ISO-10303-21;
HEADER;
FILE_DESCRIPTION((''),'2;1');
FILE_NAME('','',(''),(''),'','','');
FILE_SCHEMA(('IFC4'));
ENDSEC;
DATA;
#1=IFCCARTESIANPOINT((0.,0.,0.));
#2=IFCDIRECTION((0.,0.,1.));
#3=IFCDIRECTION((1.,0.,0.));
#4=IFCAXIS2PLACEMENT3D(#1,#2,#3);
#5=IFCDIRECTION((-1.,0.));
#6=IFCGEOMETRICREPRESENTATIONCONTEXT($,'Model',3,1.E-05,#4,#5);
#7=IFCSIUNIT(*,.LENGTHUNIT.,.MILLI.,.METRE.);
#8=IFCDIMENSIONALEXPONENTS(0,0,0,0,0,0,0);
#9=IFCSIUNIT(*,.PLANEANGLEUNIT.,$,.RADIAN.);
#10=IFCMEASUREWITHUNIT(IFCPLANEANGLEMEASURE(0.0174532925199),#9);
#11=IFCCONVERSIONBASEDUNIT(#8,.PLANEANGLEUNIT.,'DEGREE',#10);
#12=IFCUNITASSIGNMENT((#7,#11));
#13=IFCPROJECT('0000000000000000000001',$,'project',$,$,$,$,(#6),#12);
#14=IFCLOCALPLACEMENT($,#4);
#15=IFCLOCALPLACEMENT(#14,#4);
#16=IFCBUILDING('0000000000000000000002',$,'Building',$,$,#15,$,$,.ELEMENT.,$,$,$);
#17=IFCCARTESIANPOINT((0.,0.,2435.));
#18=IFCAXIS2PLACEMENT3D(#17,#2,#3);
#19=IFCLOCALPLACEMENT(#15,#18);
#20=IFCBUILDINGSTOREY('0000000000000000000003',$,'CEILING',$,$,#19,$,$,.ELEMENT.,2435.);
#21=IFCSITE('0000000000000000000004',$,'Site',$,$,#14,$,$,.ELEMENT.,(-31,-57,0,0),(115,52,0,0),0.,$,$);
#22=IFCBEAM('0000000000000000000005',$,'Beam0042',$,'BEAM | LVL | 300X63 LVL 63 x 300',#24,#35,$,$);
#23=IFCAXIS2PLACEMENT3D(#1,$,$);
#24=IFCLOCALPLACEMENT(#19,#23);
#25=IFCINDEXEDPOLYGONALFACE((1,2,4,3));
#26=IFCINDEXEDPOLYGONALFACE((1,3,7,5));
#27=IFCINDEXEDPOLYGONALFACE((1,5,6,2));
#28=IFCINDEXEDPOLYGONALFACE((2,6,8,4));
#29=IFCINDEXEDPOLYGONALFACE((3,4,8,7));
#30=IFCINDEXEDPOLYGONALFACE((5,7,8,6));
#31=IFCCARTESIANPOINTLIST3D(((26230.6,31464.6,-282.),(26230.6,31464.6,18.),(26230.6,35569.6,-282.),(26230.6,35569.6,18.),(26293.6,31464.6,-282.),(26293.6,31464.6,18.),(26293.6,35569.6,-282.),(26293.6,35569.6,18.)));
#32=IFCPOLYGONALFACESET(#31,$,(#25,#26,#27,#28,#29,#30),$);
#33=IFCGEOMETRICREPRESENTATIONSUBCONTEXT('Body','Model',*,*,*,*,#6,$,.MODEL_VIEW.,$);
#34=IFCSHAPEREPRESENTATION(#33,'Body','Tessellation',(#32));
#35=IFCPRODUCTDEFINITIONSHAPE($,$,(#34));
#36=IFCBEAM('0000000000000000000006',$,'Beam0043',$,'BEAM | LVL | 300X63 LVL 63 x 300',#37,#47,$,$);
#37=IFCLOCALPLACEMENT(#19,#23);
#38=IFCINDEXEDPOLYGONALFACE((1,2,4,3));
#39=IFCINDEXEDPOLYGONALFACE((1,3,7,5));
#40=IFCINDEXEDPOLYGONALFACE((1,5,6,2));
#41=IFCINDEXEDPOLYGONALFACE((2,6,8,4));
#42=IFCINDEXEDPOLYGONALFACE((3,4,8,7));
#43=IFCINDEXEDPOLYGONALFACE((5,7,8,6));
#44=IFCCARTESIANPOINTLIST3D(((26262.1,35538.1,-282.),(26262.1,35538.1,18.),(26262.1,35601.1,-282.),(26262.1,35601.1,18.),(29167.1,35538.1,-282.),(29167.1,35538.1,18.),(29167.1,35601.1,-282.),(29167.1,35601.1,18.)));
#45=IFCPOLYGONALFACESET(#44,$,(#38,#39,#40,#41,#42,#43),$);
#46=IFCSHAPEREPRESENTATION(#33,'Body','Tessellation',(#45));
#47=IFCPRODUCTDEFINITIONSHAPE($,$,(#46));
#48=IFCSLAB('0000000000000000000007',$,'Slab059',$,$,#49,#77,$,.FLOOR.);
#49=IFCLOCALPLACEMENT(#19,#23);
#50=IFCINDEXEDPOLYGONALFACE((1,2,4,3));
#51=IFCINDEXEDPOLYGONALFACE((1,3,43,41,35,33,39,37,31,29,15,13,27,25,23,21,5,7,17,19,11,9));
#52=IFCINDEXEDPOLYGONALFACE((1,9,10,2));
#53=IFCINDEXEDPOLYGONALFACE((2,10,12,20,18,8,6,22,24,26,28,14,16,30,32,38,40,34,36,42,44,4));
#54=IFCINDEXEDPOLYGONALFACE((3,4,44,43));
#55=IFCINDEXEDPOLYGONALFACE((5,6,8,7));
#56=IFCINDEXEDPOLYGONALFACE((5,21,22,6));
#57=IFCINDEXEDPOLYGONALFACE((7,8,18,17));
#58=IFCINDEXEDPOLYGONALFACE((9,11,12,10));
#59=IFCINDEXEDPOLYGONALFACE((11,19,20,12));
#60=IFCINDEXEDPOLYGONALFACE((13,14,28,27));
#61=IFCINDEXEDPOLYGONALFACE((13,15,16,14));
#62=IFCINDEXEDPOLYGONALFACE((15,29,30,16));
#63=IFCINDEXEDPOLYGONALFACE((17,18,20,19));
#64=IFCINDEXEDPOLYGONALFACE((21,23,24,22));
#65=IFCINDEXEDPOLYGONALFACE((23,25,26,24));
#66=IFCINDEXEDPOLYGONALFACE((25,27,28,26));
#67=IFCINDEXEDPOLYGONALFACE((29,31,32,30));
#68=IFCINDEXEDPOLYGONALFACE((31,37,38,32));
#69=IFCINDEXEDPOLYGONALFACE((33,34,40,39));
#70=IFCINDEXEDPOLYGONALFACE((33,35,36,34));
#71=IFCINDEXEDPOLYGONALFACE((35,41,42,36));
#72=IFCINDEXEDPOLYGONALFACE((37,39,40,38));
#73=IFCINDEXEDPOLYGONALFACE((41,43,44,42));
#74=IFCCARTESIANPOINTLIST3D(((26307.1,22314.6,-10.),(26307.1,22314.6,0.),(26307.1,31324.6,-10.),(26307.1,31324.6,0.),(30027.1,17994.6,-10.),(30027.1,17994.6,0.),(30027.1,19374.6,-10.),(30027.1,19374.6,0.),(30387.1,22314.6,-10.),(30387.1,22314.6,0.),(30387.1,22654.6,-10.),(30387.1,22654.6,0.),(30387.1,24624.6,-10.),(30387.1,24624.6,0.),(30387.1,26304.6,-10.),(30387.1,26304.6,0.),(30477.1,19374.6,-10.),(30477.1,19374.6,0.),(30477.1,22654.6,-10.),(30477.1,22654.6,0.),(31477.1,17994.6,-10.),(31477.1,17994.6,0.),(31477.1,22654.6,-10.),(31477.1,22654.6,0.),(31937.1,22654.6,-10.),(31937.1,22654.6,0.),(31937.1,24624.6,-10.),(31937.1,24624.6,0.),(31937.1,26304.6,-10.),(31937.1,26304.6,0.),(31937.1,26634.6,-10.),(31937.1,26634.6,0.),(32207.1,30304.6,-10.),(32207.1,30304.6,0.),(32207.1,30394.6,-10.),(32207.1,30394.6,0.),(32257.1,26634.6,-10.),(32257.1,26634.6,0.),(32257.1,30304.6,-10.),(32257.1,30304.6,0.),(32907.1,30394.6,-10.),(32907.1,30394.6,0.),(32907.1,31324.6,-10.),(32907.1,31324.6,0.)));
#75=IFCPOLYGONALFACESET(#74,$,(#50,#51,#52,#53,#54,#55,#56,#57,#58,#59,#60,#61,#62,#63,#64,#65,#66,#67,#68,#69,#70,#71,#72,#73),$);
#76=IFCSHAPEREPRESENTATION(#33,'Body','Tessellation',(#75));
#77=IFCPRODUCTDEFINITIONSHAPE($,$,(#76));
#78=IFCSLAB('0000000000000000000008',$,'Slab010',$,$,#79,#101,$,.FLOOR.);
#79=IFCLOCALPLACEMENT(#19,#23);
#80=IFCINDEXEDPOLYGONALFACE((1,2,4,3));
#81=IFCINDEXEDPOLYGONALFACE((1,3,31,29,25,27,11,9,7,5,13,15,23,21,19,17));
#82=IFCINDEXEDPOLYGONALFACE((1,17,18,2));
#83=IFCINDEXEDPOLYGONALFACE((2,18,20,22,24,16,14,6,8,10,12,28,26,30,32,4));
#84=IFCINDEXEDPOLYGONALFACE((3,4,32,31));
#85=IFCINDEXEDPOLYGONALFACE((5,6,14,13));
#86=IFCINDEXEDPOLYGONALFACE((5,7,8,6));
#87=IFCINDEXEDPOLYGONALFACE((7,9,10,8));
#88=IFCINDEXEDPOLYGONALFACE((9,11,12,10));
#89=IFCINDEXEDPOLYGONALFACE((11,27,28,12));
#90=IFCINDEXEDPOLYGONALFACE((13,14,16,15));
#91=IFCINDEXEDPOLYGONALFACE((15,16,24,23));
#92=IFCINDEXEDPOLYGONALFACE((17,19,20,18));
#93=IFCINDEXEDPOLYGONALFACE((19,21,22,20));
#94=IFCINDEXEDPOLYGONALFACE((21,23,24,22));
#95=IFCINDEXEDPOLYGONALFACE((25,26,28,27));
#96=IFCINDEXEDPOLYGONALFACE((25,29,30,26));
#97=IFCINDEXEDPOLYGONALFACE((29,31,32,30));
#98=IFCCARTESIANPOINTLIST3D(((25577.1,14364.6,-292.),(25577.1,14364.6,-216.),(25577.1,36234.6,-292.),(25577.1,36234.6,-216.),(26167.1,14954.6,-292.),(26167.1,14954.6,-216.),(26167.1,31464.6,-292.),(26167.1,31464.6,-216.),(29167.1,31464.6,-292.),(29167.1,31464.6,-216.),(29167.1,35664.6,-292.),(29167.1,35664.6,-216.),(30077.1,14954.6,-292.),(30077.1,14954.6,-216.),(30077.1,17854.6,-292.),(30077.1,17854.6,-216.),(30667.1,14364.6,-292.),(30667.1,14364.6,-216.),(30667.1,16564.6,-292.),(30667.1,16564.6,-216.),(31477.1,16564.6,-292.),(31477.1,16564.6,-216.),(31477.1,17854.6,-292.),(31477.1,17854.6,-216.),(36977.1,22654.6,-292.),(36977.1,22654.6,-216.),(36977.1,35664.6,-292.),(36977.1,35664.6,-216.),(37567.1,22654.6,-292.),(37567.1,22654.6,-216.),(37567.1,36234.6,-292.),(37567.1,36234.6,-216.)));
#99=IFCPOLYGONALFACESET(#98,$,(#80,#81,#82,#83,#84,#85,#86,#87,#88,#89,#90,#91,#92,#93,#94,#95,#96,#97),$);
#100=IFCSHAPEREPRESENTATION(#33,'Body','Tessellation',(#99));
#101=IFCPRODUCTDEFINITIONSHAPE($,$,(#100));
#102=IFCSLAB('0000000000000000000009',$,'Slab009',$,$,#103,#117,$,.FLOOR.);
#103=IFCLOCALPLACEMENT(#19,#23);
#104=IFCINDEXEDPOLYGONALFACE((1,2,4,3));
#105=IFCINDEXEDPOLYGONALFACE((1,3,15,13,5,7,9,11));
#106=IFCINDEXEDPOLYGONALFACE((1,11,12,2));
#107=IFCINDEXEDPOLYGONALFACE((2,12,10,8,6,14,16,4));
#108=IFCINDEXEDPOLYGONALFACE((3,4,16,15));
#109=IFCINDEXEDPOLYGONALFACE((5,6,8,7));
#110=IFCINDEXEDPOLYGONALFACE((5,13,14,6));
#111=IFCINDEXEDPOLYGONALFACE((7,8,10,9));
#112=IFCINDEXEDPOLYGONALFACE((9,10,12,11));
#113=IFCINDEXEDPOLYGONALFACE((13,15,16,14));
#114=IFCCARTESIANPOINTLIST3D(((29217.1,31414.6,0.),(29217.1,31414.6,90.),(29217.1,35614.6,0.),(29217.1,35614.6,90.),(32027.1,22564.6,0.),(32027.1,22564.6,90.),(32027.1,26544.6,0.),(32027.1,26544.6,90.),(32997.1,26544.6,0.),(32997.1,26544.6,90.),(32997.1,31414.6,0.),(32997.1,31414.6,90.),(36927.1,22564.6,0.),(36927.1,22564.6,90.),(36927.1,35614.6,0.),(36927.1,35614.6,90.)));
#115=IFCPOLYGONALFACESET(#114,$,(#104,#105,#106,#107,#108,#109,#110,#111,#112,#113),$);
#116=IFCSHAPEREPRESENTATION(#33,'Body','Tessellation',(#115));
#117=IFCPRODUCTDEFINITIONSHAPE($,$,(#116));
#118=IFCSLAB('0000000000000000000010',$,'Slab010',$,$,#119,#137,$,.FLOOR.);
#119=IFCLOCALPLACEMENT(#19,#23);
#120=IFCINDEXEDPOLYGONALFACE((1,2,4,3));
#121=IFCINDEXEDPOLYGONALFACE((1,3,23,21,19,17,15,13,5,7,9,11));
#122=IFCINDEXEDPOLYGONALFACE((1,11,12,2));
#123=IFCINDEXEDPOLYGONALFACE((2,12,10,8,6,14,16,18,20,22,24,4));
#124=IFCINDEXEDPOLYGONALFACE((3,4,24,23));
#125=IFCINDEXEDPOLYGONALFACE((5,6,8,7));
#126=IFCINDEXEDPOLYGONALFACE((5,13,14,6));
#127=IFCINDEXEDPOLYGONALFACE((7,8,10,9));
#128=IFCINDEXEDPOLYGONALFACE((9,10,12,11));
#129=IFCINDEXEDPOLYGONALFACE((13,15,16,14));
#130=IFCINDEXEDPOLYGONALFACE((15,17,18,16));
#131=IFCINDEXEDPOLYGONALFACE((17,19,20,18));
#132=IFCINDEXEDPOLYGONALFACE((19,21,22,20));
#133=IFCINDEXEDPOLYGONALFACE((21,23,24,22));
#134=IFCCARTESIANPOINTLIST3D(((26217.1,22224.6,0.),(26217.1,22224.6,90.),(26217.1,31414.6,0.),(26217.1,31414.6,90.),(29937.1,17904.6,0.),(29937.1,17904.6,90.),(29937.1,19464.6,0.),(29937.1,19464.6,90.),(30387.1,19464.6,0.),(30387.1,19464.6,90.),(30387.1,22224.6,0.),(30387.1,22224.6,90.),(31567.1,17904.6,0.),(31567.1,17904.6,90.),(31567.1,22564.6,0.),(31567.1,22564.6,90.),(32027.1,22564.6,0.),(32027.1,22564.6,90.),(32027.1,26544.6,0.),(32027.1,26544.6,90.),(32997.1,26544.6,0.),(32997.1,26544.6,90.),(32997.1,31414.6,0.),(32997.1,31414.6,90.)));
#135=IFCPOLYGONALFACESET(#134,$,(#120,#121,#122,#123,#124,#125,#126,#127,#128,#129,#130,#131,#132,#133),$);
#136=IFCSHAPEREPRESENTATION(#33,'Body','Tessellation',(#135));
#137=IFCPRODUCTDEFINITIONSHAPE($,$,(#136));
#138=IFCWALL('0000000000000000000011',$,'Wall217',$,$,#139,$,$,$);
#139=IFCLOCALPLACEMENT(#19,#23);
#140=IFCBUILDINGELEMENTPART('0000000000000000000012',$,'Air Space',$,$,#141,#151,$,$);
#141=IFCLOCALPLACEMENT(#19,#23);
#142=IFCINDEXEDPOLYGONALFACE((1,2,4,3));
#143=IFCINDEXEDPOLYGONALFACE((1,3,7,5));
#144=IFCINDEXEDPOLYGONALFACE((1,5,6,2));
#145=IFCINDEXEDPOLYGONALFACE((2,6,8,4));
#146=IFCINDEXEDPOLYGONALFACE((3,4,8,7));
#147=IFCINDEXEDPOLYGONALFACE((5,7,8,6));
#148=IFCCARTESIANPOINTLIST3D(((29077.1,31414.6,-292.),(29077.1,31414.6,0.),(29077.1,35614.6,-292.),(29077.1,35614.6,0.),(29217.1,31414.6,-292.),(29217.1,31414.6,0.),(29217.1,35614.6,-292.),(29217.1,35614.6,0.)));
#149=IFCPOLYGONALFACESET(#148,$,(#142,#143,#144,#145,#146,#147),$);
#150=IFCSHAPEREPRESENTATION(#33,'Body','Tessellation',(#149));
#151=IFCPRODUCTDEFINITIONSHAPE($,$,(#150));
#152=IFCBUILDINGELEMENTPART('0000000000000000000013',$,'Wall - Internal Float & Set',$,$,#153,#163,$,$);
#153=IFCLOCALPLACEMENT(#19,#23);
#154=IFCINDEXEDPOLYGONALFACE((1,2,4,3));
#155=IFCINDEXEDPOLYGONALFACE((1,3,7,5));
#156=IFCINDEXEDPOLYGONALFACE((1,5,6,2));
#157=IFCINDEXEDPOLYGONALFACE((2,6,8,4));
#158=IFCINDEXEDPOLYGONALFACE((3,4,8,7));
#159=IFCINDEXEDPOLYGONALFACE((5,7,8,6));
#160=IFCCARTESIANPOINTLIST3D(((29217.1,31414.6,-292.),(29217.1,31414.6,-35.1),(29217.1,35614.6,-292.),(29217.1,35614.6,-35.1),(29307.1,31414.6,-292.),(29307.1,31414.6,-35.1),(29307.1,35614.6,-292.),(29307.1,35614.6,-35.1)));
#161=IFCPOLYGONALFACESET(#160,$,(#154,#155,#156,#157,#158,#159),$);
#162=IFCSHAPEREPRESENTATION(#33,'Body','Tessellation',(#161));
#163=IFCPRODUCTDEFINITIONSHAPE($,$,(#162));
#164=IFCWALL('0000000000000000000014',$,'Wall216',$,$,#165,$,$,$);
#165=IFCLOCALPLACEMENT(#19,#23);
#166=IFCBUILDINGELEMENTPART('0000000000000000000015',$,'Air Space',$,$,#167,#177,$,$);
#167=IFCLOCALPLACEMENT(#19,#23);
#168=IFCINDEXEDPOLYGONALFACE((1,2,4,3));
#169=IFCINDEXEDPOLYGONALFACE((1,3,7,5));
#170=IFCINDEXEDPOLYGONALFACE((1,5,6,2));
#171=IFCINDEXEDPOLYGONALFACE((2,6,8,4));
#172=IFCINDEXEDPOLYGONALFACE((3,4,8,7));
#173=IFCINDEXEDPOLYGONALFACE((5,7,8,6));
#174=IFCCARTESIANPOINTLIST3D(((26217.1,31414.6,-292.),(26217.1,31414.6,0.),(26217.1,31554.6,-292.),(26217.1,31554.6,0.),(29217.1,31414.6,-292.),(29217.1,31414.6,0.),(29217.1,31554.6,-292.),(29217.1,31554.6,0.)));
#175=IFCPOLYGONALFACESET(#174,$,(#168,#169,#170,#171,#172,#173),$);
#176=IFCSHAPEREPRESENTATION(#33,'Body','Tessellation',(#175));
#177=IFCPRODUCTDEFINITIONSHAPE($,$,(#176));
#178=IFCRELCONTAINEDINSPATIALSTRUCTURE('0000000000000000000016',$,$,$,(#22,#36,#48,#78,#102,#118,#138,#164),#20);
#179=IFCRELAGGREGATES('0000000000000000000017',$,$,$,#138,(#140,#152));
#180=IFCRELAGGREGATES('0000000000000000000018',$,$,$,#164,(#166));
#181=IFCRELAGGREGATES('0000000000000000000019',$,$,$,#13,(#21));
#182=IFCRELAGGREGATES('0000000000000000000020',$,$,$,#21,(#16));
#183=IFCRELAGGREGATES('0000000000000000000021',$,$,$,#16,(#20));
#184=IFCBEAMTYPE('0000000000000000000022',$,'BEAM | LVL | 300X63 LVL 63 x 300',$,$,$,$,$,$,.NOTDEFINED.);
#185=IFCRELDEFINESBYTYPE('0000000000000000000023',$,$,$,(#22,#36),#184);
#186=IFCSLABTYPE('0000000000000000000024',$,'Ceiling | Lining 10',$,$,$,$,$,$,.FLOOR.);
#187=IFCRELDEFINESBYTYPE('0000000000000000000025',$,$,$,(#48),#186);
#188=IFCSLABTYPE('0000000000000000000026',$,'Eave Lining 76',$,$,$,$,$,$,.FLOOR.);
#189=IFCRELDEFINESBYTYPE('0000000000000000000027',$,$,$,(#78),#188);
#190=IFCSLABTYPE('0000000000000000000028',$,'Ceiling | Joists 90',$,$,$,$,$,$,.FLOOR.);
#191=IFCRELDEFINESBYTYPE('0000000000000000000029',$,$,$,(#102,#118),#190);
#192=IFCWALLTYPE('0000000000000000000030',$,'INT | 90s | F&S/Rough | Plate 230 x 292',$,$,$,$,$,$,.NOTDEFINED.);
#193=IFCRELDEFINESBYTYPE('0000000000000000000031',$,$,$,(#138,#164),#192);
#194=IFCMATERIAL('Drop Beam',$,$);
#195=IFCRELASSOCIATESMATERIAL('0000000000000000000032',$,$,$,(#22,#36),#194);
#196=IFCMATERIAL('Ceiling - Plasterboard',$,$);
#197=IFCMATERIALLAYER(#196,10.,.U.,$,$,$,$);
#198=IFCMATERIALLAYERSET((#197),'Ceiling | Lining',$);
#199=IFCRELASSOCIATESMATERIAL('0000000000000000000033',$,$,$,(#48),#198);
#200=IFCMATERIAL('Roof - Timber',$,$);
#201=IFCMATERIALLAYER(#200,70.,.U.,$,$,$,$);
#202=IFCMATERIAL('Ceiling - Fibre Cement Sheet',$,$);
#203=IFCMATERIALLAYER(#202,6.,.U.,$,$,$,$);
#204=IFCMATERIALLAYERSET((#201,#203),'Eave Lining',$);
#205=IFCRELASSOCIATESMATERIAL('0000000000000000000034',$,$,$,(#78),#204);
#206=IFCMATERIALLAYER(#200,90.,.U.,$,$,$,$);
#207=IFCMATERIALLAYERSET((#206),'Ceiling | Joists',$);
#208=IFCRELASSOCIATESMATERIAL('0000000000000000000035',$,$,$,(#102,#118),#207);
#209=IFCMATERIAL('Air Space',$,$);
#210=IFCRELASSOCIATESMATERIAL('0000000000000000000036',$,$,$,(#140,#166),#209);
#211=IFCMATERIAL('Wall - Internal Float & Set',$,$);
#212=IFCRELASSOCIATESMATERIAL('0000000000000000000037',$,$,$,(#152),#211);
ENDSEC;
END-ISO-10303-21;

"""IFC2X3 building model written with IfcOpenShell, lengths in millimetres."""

from ifc_helpers import new_model, entity, si_unit, converted_unit, direction, frame, origin_with_axes, place, context, subcontext, project, spatial, polyline, outline, extrude, material, layer, layer_set, layer_usage, type_object, element, aggregate, save


model = new_model("IFC2X3")

# Units and contexts
model_context = context("Model", 3, precision=1e-05, world=origin_with_axes(), true_north=direction((-1.0, 0.0)))
body_context = subcontext(model_context, "Body", "Model", "MODEL_VIEW")
ifc_project = project(units=[si_unit("LENGTHUNIT", "METRE", prefix="MILLI"), converted_unit("PLANEANGLEUNIT", "DEGREE", entity("IfcPlaneAngleMeasure", 0.0174532925199), si_unit("PLANEANGLEUNIT", "RADIAN"), dimensions=[0, 0, 0, 0, 0, 0, 0])], contexts=[model_context])

# Site, building, storey
site_placement = place(None, origin_with_axes())
site = spatial("IfcSite", under=ifc_project, at=site_placement, Name="Site", CompositionType="ELEMENT", RefLatitude=(-31, -57, 0, 0), RefLongitude=(115, 52, 0, 0), RefElevation=0.0)
building_placement = place(site_placement, origin_with_axes())
building = spatial("IfcBuilding", under=site, at=building_placement, Name="Building", CompositionType="ELEMENT")
storey_placement = place(building_placement, frame((0.0, 0.0, 2435.0), z_axis=(0.0, 0.0, 1.0), x_axis=(1.0, 0.0, 0.0)))
storey = spatial("IfcBuildingStorey", under=building, at=storey_placement, Name="CEILING", CompositionType="ELEMENT", Elevation=2435.0)

# Beams
ifc_material_1 = material(Name="Drop Beam")
beam_type = type_object("IfcBeamType", Name="BEAM | LVL | 300X63 LVL 63 x 300", PredefinedType="NOTDEFINED")
beam_1_placement = place(storey_placement, frame((26262.1, 31464.6, -282.0), z_axis=(0.0, 0.0, 1.0), x_axis=(1.0, 0.0, 0.0)))
element("IfcBeam", 1, at=beam_1_placement, inside=storey, type_object=beam_type, material=ifc_material_1, Name="Beam0042", ObjectType="BEAM | LVL | 300X63 LVL 63 x 300", context=body_context, shape_type="SweptSolid", body=[
    extrude(outline(polyline([(-31.5, 300.0), (-31.5, 0.0), (31.5, 0.0), (31.5, 300.0), (-31.5, 300.0)])), frame((0.0, 4105.0, 0.0), z_axis=(0.0, -1.0, 0.0), x_axis=(1.0, 0.0, 0.0)), (0.0, 0.0, 1.0), 4105.0),
])
beam_2_placement = place(storey_placement, frame((26262.1, 35569.6, -282.0), z_axis=(0.0, 0.0, 1.0), x_axis=(0.0, -1.0, 0.0)))
element("IfcBeam", 2, at=beam_2_placement, inside=storey, type_object=beam_type, material=ifc_material_1, Name="Beam0043", ObjectType="BEAM | LVL | 300X63 LVL 63 x 300", context=body_context, shape_type="SweptSolid", body=[
    extrude(outline(polyline([(-31.5, 300.0), (-31.5, 0.0), (31.5, 0.0), (31.5, 300.0), (-31.5, 300.0)])), frame((0.0, 2905.0, 0.0), z_axis=(0.0, -1.0, 0.0), x_axis=(1.0, 0.0, 0.0)), (0.0, 0.0, 1.0), 2905.0),
])

# Slabs
ifc_material_2 = material(Name="Ceiling - Plasterboard")
ifc_layer_1 = layer(ifc_material_2, 10.0, ventilated="UNKNOWN")
ifc_layer_set_1 = layer_set([ifc_layer_1], Name="Ceiling | Lining")
ifc_layer_usage_1 = layer_usage(ifc_layer_set_1, "AXIS3", "NEGATIVE", 10.0)
slab_type_1 = type_object("IfcSlabType", Name="Ceiling | Lining 10", PredefinedType="FLOOR")
slab_1_placement = place(storey_placement, frame((26307.1, 31324.6, 0.0), z_axis=(0.0, 0.0, 1.0), x_axis=(1.0, 0.0, 0.0)))
element("IfcSlab", 3, at=slab_1_placement, inside=storey, type_object=slab_type_1, material=ifc_layer_usage_1, Name="Slab059", PredefinedType="FLOOR", context=body_context, shape_type="SweptSolid", body=[
    extrude(outline(polyline([(0.0, 0.0), (0.0, -9010.0), (4080.0, -9010.0), (4080.0, -8670.0), (4170.0, -8670.0), (4170.0, -11950.0), (3720.0, -11950.0), (3720.0, -13330.0), (5170.0, -13330.0), (5170.0, -8670.0), (5630.0, -8670.0), (5630.0, -6700.0), (4080.0, -6700.0), (4080.0, -5020.0), (5630.0, -5020.0), (5630.0, -4690.0), (5950.0, -4690.0), (5950.0, -1020.0), (5900.0, -1020.0), (5900.0, -930.0), (6600.0, -930.0), (6600.0, 0.0), (0.0, 0.0)])), frame((0.0, 0.0, -10.0), z_axis=(0.0, 0.0, 1.0), x_axis=(1.0, 0.0, 0.0)), (0.0, 0.0, 1.0), 10.0),
])
ifc_material_3 = material(Name="Roof - Timber")
ifc_layer_2 = layer(ifc_material_3, 70.0, ventilated="UNKNOWN")
ifc_material_4 = material(Name="Ceiling - Fibre Cement Sheet")
ifc_layer_3 = layer(ifc_material_4, 6.0, ventilated="UNKNOWN")
ifc_layer_set_2 = layer_set([ifc_layer_2, ifc_layer_3], Name="Eave Lining")
ifc_layer_usage_2 = layer_usage(ifc_layer_set_2, "AXIS3", "NEGATIVE", 76.0)
slab_type_2 = type_object("IfcSlabType", Name="Eave Lining 76", PredefinedType="FLOOR")
slab_2_placement = place(storey_placement, frame((25577.1, 36234.6, -216.0), z_axis=(0.0, 0.0, 1.0), x_axis=(1.0, 0.0, 0.0)))
element("IfcSlab", 4, at=slab_2_placement, inside=storey, type_object=slab_type_2, material=ifc_layer_usage_2, Name="Slab010", PredefinedType="FLOOR", context=body_context, shape_type="SweptSolid", body=[
    extrude(outline(polyline([(0.0, 0.0), (0.0, -21870.0), (5090.0, -21870.0), (5090.0, -19670.0), (5900.0, -19670.0), (5900.0, -18380.0), (4500.0, -18380.0), (4500.0, -21280.0), (590.0, -21280.0), (590.0, -4770.0), (3590.0, -4770.0), (3590.0, -570.0), (11400.0, -570.0), (11400.0, -13580.0), (11990.0, -13580.0), (11990.0, 0.0), (0.0, 0.0)])), frame((0.0, 0.0, -76.0), z_axis=(0.0, 0.0, 1.0), x_axis=(1.0, 0.0, 0.0)), (0.0, 0.0, 1.0), 76.0),
])
ifc_layer_4 = layer(ifc_material_3, 90.0, ventilated="UNKNOWN")
ifc_layer_set_3 = layer_set([ifc_layer_4], Name="Ceiling | Joists")
ifc_layer_usage_3 = layer_usage(ifc_layer_set_3, "AXIS3", "NEGATIVE", 90.0)
slab_type_3 = type_object("IfcSlabType", Name="Ceiling | Joists 90", PredefinedType="FLOOR")
slab_3_placement = place(storey_placement, frame((29217.1, 31414.6, 0.0), z_axis=(0.0, 0.0, 1.0), x_axis=(1.0, 0.0, 0.0)))
element("IfcSlab", 5, at=slab_3_placement, inside=storey, type_object=slab_type_3, material=ifc_layer_usage_3, Name="Slab009", PredefinedType="FLOOR", context=body_context, shape_type="SweptSolid", body=[
    extrude(outline(polyline([(0.0, 0.0), (3780.0, 0.0), (3780.0, -4870.0), (2810.0, -4870.0), (2810.0, -8850.0), (7710.0, -8850.0), (7710.0, 4200.0), (0.0, 4200.0), (0.0, 0.0)])), origin_with_axes(), (0.0, 0.0, 1.0), 90.0),
])
ifc_layer_usage_4 = layer_usage(ifc_layer_set_3, "AXIS3", "NEGATIVE", 90.0)
slab_4_placement = place(storey_placement, frame((26217.1, 31414.6, 0.0), z_axis=(0.0, 0.0, 1.0), x_axis=(1.0, 0.0, 0.0)))
element("IfcSlab", 6, at=slab_4_placement, inside=storey, type_object=slab_type_3, material=ifc_layer_usage_4, Name="Slab010", PredefinedType="FLOOR", context=body_context, shape_type="SweptSolid", body=[
    extrude(outline(polyline([(0.0, 0.0), (0.0, -9190.0), (4170.0, -9190.0), (4170.0, -11950.0), (3720.0, -11950.0), (3720.0, -13510.0), (5350.0, -13510.0), (5350.0, -8850.0), (5810.0, -8850.0), (5810.0, -4870.0), (6780.0, -4870.0), (6780.0, 0.0), (0.0, 0.0)])), origin_with_axes(), (0.0, 0.0, 1.0), 90.0),
])

# Walls, building element parts
wall_type = type_object("IfcWallType", Name="INT | 90s | F&S/Rough | Plate 230 x 292", PredefinedType="NOTDEFINED")
wall_1_placement = place(storey_placement, frame((29217.1, 31414.6, -292.0), z_axis=(0.0, 0.0, 1.0), x_axis=(0.0, 1.0, 0.0)))
wall_1 = element("IfcWall", 7, at=wall_1_placement, inside=storey, type_object=wall_type, Name="Wall217")
ifc_material_5 = material(Name="Air Space")
building_element_part_1_placement = place(wall_1_placement, origin_with_axes())
building_element_part_1 = element("IfcBuildingElementPart", 8, at=building_element_part_1_placement, material=ifc_material_5, Name="Air Space", context=body_context, shape_type="SweptSolid", body=[
    extrude(outline(polyline([(0.0, 292.0), (0.0, 0.0), (140.0, 0.0), (140.0, 292.0), (0.0, 292.0)])), frame((0.0, 0.0, 0.0), z_axis=(1.0, 0.0, 0.0), x_axis=(0.0, 1.0, 0.0)), (0.0, 0.0, 1.0), 4200.0),
])
ifc_material_6 = material(Name="Wall - Internal Float & Set")
building_element_part_2_placement = place(wall_1_placement, origin_with_axes())
building_element_part_2 = element("IfcBuildingElementPart", 9, at=building_element_part_2_placement, material=ifc_material_6, Name="Wall - Internal Float & Set", context=body_context, shape_type="SweptSolid", body=[
    extrude(outline(polyline([(-90.0, 256.9), (-90.0, 0.0), (0.0, 0.0), (0.0, 256.9), (-90.0, 256.9)])), frame((0.0, 0.0, 0.0), z_axis=(1.0, 0.0, 0.0), x_axis=(0.0, 1.0, 0.0)), (0.0, 0.0, 1.0), 4200.0),
])
aggregate(wall_1, [building_element_part_1, building_element_part_2])
wall_2_placement = place(storey_placement, frame((26217.1, 31414.6, -292.0), z_axis=(0.0, 0.0, 1.0), x_axis=(1.0, 0.0, 0.0)))
wall_2 = element("IfcWall", 10, at=wall_2_placement, inside=storey, type_object=wall_type, Name="Wall216")
building_element_part_3_placement = place(wall_2_placement, origin_with_axes())
building_element_part_3 = element("IfcBuildingElementPart", 11, at=building_element_part_3_placement, material=ifc_material_5, Name="Air Space", context=body_context, shape_type="SweptSolid", body=[
    extrude(outline(polyline([(0.0, 292.0), (0.0, 0.0), (140.0, 0.0), (140.0, 292.0), (0.0, 292.0)])), frame((0.0, 0.0, 0.0), z_axis=(1.0, 0.0, 0.0), x_axis=(0.0, 1.0, 0.0)), (0.0, 0.0, 1.0), 3000.0),
])
aggregate(wall_2, [building_element_part_3])

save(model, "model.ifc")
